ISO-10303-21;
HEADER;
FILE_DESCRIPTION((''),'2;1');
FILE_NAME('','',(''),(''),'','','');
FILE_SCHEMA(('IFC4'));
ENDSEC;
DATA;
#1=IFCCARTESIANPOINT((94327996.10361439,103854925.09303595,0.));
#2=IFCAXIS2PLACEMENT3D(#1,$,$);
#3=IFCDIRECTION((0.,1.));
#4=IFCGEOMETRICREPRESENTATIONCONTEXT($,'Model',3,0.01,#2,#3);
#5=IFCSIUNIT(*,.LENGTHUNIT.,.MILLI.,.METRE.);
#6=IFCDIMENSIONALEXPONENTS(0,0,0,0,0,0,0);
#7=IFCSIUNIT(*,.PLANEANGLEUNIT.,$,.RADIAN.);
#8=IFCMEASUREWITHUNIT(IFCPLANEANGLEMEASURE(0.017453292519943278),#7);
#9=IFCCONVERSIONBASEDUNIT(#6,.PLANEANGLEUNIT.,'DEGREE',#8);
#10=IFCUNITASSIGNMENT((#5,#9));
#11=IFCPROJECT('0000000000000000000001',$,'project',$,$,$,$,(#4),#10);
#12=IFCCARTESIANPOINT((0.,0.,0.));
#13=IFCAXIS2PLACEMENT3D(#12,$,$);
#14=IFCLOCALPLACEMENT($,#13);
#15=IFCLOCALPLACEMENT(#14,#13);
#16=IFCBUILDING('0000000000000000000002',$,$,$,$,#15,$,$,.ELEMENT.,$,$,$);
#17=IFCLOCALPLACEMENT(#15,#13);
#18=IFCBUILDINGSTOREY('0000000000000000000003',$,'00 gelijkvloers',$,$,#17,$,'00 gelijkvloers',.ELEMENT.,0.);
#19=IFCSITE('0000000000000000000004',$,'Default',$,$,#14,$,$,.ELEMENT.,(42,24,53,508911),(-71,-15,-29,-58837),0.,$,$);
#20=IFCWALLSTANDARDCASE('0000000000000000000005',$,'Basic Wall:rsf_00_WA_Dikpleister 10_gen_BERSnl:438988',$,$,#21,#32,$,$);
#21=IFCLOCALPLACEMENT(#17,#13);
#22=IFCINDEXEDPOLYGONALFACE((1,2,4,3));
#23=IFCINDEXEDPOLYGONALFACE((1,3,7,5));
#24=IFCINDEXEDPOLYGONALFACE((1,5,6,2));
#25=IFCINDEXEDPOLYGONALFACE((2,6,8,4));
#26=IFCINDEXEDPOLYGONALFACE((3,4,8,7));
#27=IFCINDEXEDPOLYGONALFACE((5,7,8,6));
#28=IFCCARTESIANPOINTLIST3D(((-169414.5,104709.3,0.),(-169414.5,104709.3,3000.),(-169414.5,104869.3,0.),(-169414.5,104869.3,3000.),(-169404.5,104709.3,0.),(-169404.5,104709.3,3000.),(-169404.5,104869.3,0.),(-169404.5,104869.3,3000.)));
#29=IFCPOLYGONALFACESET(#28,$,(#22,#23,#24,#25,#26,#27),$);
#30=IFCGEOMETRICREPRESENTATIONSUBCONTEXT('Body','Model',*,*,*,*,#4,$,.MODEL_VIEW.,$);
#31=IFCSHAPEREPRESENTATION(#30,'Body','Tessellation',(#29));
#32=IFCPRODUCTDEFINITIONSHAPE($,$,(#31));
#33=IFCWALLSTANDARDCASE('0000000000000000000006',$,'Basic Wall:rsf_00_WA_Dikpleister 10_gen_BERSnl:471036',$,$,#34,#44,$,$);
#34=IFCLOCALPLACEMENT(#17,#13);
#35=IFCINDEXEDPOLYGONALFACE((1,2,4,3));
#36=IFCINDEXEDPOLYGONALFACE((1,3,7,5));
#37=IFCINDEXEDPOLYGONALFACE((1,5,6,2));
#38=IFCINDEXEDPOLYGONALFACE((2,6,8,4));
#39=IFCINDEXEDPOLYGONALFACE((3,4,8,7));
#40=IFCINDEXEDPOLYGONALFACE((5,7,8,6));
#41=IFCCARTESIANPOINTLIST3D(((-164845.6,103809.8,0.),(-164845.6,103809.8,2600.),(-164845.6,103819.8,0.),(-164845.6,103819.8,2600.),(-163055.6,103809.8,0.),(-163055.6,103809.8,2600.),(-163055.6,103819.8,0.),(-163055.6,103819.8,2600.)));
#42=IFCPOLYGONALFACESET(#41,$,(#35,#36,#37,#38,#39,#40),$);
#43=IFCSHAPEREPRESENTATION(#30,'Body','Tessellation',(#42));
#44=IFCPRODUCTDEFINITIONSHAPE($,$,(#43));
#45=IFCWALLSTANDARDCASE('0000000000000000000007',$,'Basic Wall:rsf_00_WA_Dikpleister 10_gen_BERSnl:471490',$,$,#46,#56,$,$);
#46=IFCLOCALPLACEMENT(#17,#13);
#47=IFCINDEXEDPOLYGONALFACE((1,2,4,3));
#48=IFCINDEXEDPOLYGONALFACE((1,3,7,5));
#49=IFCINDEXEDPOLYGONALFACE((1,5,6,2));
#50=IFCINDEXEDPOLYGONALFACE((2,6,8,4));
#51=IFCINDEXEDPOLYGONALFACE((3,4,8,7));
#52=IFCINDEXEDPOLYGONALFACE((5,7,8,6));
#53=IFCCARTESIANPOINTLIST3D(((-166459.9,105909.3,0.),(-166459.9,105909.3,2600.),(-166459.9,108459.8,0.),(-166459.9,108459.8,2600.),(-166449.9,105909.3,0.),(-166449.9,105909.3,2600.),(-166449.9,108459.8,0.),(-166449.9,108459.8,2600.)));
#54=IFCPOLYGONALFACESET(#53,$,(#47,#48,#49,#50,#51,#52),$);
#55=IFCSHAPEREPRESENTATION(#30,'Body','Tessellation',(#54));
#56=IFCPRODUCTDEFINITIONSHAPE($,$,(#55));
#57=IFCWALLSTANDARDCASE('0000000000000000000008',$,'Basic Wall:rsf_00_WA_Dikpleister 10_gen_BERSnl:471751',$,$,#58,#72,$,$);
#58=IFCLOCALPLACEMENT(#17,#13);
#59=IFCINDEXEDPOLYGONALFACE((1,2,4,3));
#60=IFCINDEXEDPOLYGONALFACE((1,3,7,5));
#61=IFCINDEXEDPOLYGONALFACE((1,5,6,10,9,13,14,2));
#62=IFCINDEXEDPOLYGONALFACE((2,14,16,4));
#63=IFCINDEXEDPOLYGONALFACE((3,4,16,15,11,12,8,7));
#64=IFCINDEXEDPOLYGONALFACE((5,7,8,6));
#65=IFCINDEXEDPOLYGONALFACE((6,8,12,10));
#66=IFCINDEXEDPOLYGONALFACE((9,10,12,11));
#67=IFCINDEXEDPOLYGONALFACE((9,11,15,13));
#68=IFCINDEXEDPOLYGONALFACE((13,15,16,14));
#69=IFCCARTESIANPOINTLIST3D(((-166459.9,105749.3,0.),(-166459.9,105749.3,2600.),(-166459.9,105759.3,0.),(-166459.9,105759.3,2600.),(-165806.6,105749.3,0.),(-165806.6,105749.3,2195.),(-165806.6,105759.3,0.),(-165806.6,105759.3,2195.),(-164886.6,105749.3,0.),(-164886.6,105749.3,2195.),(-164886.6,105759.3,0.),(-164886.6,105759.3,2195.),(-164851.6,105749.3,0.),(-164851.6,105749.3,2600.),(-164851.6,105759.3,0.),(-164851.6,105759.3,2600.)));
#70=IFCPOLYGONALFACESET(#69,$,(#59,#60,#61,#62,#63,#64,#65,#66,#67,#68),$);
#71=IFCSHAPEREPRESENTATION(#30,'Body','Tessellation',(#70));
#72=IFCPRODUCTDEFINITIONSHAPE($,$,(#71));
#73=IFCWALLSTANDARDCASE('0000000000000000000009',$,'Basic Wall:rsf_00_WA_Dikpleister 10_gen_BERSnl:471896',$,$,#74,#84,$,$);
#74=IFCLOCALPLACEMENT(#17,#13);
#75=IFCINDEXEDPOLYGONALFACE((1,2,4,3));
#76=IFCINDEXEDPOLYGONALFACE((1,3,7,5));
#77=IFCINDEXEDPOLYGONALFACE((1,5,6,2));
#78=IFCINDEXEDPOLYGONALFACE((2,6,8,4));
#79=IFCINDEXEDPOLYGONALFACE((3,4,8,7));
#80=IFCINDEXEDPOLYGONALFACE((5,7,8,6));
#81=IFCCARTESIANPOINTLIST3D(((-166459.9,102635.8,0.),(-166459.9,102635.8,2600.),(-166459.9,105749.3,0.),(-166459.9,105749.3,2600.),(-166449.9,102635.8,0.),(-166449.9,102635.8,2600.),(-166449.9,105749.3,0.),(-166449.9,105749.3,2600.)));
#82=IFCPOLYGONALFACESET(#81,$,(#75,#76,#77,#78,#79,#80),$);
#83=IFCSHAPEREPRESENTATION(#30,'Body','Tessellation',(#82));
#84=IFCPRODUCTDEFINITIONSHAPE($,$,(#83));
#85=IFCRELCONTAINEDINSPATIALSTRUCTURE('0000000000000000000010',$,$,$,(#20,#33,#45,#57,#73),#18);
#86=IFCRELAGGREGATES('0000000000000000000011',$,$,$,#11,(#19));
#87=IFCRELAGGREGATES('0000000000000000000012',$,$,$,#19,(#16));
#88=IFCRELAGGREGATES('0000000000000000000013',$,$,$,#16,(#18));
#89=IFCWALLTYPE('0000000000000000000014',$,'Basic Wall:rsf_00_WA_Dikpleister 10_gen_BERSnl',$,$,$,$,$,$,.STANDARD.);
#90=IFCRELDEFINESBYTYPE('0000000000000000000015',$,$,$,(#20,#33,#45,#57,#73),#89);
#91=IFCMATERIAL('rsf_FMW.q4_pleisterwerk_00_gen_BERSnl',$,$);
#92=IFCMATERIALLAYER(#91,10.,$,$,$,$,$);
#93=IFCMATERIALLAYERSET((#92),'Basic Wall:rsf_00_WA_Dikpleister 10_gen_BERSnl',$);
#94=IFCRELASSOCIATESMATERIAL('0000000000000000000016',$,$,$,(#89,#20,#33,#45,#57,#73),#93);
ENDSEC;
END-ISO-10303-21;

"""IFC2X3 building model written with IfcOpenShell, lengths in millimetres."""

from ifc_helpers import new_model, entity, si_unit, converted_unit, direction, frame, frame_2d, origin, place, context, subcontext, project, spatial, rectangle, extrude, material, layer, layer_set, layer_usage, type_object, element, save


model = new_model("IFC2X3")

# Units and contexts
model_context = context("Model", 3, precision=0.01, world=frame((94327996.10361439, 103854925.09303595, 0.0)), true_north=direction((0.0, 1.0)))
body_context = subcontext(model_context, "Body", "Model", "MODEL_VIEW")
ifc_project = project(units=[si_unit("LENGTHUNIT", "METRE", prefix="MILLI"), converted_unit("PLANEANGLEUNIT", "DEGREE", entity("IfcPlaneAngleMeasure", 0.017453292519943278), si_unit("PLANEANGLEUNIT", "RADIAN"), dimensions=[0, 0, 0, 0, 0, 0, 0])], contexts=[model_context])

# Site, building, storey
site_placement = place(None, origin())
site = spatial("IfcSite", under=ifc_project, at=site_placement, Name="Default", CompositionType="ELEMENT", RefLatitude=(42, 24, 53, 508911), RefLongitude=(-71, -15, -29, -58837), RefElevation=0.0)
building_placement = place(site_placement, origin())
building = spatial("IfcBuilding", under=site, at=building_placement, CompositionType="ELEMENT")
storey_placement = place(building_placement, origin())
storey = spatial("IfcBuildingStorey", under=building, at=storey_placement, Name="00 gelijkvloers", LongName="00 gelijkvloers", CompositionType="ELEMENT", Elevation=0.0)

# Shared definitions
ifc_material_1 = material(Name="rsf_FMW.q4_pleisterwerk_00_gen_BERSnl")
ifc_layer_1 = layer(ifc_material_1, 10.0)
ifc_layer_set_1 = layer_set([ifc_layer_1], Name="Basic Wall:rsf_00_WA_Dikpleister 10_gen_BERSnl")
wall_type_1 = type_object("IfcWallType", Name="Basic Wall:rsf_00_WA_Dikpleister 10_gen_BERSnl", PredefinedType="STANDARD", material=ifc_layer_set_1)

# Walls
ifc_layer_usage_1 = layer_usage(ifc_layer_set_1, "AXIS2", "NEGATIVE", 5.0)
wall_1_placement = place(storey_placement, frame((-169409.5, 104869.3, 0.0), z_axis=(0.0, 0.0, 1.0), x_axis=(0.0, -1.0, 0.0)))
element("IfcWallStandardCase", 1, at=wall_1_placement, inside=storey, type_object=wall_type_1, material=ifc_layer_usage_1, Name="Basic Wall:rsf_00_WA_Dikpleister 10_gen_BERSnl:438988", context=body_context, shape_type="SweptSolid", body=[
    extrude(rectangle(XDim=160.0, YDim=10.0, at=frame_2d((80.0, 0.0), x_axis=(-1.0, 0.0))), origin(), (0.0, 0.0, 1.0), 3000.0),
])
ifc_layer_usage_2 = layer_usage(ifc_layer_set_1, "AXIS2", "NEGATIVE", 5.0)
wall_2_placement = place(storey_placement, frame((-164845.6, 103814.8, 0.0)))
element("IfcWallStandardCase", 2, at=wall_2_placement, inside=storey, type_object=wall_type_1, material=ifc_layer_usage_2, Name="Basic Wall:rsf_00_WA_Dikpleister 10_gen_BERSnl:471036", context=body_context, shape_type="SweptSolid", body=[
    extrude(rectangle(XDim=1790.0, YDim=10.0, at=frame_2d((895.0, 0.0), x_axis=(-1.0, 0.0))), origin(), (0.0, 0.0, 1.0), 2600.0),
])
ifc_layer_usage_3 = layer_usage(ifc_layer_set_1, "AXIS2", "NEGATIVE", 5.0)
wall_3_placement = place(storey_placement, frame((-166454.9, 108459.8, 0.0), z_axis=(0.0, 0.0, 1.0), x_axis=(0.0, -1.0, 0.0)))
element("IfcWallStandardCase", 3, at=wall_3_placement, inside=storey, type_object=wall_type_1, material=ifc_layer_usage_3, Name="Basic Wall:rsf_00_WA_Dikpleister 10_gen_BERSnl:471490", context=body_context, shape_type="SweptSolid", body=[
    extrude(rectangle(XDim=2550.5, YDim=10.0, at=frame_2d((1275.2, 0.0), x_axis=(-1.0, 0.0))), origin(), (0.0, 0.0, 1.0), 2600.0),
])

# Wall, opening
ifc_layer_usage_4 = layer_usage(ifc_layer_set_1, "AXIS2", "NEGATIVE", 5.0)
wall_4_placement = place(storey_placement, frame((-164851.6, 105754.3, 0.0), z_axis=(0.0, 0.0, 1.0), x_axis=(-1.0, 0.0, 0.0)))
wall_4 = element("IfcWallStandardCase", 4, at=wall_4_placement, inside=storey, type_object=wall_type_1, material=ifc_layer_usage_4, Name="Basic Wall:rsf_00_WA_Dikpleister 10_gen_BERSnl:471751", context=body_context, shape_type="SweptSolid", body=[
    extrude(rectangle(XDim=1608.3, YDim=10.0, at=frame_2d((804.1, 0.0), x_axis=(1.0, 0.0))), origin(), (0.0, 0.0, 1.0), 2600.0),
])
opening_1_placement = place(wall_4_placement, frame((35.0, -5.0, -180.0)))
element("IfcOpeningElement", 5, at=opening_1_placement, cuts=wall_4, ObjectType="Opening", context=body_context, shape_type="SweptSolid", body=[
    extrude(rectangle(XDim=2375.0, YDim=920.0, at=frame_2d((1187.5, 460.0), x_axis=(-1.0, 0.0))), frame((0.0, 0.0, 0.0), z_axis=(0.0, 1.0, 0.0), x_axis=(0.0, 0.0, 1.0)), (0.0, 0.0, 1.0), 10.0),
])

# Wall
ifc_layer_usage_5 = layer_usage(ifc_layer_set_1, "AXIS2", "NEGATIVE", 5.0)
wall_5_placement = place(storey_placement, frame((-166454.9, 105749.3, 0.0), z_axis=(0.0, 0.0, 1.0), x_axis=(0.0, -1.0, 0.0)))
element("IfcWallStandardCase", 6, at=wall_5_placement, inside=storey, type_object=wall_type_1, material=ifc_layer_usage_5, Name="Basic Wall:rsf_00_WA_Dikpleister 10_gen_BERSnl:471896", context=body_context, shape_type="SweptSolid", body=[
    extrude(rectangle(XDim=3113.5, YDim=10.0, at=frame_2d((1556.8, 0.0), x_axis=(-1.0, 0.0))), origin(), (0.0, 0.0, 1.0), 2600.0),
])

save(model, "model.ifc")
